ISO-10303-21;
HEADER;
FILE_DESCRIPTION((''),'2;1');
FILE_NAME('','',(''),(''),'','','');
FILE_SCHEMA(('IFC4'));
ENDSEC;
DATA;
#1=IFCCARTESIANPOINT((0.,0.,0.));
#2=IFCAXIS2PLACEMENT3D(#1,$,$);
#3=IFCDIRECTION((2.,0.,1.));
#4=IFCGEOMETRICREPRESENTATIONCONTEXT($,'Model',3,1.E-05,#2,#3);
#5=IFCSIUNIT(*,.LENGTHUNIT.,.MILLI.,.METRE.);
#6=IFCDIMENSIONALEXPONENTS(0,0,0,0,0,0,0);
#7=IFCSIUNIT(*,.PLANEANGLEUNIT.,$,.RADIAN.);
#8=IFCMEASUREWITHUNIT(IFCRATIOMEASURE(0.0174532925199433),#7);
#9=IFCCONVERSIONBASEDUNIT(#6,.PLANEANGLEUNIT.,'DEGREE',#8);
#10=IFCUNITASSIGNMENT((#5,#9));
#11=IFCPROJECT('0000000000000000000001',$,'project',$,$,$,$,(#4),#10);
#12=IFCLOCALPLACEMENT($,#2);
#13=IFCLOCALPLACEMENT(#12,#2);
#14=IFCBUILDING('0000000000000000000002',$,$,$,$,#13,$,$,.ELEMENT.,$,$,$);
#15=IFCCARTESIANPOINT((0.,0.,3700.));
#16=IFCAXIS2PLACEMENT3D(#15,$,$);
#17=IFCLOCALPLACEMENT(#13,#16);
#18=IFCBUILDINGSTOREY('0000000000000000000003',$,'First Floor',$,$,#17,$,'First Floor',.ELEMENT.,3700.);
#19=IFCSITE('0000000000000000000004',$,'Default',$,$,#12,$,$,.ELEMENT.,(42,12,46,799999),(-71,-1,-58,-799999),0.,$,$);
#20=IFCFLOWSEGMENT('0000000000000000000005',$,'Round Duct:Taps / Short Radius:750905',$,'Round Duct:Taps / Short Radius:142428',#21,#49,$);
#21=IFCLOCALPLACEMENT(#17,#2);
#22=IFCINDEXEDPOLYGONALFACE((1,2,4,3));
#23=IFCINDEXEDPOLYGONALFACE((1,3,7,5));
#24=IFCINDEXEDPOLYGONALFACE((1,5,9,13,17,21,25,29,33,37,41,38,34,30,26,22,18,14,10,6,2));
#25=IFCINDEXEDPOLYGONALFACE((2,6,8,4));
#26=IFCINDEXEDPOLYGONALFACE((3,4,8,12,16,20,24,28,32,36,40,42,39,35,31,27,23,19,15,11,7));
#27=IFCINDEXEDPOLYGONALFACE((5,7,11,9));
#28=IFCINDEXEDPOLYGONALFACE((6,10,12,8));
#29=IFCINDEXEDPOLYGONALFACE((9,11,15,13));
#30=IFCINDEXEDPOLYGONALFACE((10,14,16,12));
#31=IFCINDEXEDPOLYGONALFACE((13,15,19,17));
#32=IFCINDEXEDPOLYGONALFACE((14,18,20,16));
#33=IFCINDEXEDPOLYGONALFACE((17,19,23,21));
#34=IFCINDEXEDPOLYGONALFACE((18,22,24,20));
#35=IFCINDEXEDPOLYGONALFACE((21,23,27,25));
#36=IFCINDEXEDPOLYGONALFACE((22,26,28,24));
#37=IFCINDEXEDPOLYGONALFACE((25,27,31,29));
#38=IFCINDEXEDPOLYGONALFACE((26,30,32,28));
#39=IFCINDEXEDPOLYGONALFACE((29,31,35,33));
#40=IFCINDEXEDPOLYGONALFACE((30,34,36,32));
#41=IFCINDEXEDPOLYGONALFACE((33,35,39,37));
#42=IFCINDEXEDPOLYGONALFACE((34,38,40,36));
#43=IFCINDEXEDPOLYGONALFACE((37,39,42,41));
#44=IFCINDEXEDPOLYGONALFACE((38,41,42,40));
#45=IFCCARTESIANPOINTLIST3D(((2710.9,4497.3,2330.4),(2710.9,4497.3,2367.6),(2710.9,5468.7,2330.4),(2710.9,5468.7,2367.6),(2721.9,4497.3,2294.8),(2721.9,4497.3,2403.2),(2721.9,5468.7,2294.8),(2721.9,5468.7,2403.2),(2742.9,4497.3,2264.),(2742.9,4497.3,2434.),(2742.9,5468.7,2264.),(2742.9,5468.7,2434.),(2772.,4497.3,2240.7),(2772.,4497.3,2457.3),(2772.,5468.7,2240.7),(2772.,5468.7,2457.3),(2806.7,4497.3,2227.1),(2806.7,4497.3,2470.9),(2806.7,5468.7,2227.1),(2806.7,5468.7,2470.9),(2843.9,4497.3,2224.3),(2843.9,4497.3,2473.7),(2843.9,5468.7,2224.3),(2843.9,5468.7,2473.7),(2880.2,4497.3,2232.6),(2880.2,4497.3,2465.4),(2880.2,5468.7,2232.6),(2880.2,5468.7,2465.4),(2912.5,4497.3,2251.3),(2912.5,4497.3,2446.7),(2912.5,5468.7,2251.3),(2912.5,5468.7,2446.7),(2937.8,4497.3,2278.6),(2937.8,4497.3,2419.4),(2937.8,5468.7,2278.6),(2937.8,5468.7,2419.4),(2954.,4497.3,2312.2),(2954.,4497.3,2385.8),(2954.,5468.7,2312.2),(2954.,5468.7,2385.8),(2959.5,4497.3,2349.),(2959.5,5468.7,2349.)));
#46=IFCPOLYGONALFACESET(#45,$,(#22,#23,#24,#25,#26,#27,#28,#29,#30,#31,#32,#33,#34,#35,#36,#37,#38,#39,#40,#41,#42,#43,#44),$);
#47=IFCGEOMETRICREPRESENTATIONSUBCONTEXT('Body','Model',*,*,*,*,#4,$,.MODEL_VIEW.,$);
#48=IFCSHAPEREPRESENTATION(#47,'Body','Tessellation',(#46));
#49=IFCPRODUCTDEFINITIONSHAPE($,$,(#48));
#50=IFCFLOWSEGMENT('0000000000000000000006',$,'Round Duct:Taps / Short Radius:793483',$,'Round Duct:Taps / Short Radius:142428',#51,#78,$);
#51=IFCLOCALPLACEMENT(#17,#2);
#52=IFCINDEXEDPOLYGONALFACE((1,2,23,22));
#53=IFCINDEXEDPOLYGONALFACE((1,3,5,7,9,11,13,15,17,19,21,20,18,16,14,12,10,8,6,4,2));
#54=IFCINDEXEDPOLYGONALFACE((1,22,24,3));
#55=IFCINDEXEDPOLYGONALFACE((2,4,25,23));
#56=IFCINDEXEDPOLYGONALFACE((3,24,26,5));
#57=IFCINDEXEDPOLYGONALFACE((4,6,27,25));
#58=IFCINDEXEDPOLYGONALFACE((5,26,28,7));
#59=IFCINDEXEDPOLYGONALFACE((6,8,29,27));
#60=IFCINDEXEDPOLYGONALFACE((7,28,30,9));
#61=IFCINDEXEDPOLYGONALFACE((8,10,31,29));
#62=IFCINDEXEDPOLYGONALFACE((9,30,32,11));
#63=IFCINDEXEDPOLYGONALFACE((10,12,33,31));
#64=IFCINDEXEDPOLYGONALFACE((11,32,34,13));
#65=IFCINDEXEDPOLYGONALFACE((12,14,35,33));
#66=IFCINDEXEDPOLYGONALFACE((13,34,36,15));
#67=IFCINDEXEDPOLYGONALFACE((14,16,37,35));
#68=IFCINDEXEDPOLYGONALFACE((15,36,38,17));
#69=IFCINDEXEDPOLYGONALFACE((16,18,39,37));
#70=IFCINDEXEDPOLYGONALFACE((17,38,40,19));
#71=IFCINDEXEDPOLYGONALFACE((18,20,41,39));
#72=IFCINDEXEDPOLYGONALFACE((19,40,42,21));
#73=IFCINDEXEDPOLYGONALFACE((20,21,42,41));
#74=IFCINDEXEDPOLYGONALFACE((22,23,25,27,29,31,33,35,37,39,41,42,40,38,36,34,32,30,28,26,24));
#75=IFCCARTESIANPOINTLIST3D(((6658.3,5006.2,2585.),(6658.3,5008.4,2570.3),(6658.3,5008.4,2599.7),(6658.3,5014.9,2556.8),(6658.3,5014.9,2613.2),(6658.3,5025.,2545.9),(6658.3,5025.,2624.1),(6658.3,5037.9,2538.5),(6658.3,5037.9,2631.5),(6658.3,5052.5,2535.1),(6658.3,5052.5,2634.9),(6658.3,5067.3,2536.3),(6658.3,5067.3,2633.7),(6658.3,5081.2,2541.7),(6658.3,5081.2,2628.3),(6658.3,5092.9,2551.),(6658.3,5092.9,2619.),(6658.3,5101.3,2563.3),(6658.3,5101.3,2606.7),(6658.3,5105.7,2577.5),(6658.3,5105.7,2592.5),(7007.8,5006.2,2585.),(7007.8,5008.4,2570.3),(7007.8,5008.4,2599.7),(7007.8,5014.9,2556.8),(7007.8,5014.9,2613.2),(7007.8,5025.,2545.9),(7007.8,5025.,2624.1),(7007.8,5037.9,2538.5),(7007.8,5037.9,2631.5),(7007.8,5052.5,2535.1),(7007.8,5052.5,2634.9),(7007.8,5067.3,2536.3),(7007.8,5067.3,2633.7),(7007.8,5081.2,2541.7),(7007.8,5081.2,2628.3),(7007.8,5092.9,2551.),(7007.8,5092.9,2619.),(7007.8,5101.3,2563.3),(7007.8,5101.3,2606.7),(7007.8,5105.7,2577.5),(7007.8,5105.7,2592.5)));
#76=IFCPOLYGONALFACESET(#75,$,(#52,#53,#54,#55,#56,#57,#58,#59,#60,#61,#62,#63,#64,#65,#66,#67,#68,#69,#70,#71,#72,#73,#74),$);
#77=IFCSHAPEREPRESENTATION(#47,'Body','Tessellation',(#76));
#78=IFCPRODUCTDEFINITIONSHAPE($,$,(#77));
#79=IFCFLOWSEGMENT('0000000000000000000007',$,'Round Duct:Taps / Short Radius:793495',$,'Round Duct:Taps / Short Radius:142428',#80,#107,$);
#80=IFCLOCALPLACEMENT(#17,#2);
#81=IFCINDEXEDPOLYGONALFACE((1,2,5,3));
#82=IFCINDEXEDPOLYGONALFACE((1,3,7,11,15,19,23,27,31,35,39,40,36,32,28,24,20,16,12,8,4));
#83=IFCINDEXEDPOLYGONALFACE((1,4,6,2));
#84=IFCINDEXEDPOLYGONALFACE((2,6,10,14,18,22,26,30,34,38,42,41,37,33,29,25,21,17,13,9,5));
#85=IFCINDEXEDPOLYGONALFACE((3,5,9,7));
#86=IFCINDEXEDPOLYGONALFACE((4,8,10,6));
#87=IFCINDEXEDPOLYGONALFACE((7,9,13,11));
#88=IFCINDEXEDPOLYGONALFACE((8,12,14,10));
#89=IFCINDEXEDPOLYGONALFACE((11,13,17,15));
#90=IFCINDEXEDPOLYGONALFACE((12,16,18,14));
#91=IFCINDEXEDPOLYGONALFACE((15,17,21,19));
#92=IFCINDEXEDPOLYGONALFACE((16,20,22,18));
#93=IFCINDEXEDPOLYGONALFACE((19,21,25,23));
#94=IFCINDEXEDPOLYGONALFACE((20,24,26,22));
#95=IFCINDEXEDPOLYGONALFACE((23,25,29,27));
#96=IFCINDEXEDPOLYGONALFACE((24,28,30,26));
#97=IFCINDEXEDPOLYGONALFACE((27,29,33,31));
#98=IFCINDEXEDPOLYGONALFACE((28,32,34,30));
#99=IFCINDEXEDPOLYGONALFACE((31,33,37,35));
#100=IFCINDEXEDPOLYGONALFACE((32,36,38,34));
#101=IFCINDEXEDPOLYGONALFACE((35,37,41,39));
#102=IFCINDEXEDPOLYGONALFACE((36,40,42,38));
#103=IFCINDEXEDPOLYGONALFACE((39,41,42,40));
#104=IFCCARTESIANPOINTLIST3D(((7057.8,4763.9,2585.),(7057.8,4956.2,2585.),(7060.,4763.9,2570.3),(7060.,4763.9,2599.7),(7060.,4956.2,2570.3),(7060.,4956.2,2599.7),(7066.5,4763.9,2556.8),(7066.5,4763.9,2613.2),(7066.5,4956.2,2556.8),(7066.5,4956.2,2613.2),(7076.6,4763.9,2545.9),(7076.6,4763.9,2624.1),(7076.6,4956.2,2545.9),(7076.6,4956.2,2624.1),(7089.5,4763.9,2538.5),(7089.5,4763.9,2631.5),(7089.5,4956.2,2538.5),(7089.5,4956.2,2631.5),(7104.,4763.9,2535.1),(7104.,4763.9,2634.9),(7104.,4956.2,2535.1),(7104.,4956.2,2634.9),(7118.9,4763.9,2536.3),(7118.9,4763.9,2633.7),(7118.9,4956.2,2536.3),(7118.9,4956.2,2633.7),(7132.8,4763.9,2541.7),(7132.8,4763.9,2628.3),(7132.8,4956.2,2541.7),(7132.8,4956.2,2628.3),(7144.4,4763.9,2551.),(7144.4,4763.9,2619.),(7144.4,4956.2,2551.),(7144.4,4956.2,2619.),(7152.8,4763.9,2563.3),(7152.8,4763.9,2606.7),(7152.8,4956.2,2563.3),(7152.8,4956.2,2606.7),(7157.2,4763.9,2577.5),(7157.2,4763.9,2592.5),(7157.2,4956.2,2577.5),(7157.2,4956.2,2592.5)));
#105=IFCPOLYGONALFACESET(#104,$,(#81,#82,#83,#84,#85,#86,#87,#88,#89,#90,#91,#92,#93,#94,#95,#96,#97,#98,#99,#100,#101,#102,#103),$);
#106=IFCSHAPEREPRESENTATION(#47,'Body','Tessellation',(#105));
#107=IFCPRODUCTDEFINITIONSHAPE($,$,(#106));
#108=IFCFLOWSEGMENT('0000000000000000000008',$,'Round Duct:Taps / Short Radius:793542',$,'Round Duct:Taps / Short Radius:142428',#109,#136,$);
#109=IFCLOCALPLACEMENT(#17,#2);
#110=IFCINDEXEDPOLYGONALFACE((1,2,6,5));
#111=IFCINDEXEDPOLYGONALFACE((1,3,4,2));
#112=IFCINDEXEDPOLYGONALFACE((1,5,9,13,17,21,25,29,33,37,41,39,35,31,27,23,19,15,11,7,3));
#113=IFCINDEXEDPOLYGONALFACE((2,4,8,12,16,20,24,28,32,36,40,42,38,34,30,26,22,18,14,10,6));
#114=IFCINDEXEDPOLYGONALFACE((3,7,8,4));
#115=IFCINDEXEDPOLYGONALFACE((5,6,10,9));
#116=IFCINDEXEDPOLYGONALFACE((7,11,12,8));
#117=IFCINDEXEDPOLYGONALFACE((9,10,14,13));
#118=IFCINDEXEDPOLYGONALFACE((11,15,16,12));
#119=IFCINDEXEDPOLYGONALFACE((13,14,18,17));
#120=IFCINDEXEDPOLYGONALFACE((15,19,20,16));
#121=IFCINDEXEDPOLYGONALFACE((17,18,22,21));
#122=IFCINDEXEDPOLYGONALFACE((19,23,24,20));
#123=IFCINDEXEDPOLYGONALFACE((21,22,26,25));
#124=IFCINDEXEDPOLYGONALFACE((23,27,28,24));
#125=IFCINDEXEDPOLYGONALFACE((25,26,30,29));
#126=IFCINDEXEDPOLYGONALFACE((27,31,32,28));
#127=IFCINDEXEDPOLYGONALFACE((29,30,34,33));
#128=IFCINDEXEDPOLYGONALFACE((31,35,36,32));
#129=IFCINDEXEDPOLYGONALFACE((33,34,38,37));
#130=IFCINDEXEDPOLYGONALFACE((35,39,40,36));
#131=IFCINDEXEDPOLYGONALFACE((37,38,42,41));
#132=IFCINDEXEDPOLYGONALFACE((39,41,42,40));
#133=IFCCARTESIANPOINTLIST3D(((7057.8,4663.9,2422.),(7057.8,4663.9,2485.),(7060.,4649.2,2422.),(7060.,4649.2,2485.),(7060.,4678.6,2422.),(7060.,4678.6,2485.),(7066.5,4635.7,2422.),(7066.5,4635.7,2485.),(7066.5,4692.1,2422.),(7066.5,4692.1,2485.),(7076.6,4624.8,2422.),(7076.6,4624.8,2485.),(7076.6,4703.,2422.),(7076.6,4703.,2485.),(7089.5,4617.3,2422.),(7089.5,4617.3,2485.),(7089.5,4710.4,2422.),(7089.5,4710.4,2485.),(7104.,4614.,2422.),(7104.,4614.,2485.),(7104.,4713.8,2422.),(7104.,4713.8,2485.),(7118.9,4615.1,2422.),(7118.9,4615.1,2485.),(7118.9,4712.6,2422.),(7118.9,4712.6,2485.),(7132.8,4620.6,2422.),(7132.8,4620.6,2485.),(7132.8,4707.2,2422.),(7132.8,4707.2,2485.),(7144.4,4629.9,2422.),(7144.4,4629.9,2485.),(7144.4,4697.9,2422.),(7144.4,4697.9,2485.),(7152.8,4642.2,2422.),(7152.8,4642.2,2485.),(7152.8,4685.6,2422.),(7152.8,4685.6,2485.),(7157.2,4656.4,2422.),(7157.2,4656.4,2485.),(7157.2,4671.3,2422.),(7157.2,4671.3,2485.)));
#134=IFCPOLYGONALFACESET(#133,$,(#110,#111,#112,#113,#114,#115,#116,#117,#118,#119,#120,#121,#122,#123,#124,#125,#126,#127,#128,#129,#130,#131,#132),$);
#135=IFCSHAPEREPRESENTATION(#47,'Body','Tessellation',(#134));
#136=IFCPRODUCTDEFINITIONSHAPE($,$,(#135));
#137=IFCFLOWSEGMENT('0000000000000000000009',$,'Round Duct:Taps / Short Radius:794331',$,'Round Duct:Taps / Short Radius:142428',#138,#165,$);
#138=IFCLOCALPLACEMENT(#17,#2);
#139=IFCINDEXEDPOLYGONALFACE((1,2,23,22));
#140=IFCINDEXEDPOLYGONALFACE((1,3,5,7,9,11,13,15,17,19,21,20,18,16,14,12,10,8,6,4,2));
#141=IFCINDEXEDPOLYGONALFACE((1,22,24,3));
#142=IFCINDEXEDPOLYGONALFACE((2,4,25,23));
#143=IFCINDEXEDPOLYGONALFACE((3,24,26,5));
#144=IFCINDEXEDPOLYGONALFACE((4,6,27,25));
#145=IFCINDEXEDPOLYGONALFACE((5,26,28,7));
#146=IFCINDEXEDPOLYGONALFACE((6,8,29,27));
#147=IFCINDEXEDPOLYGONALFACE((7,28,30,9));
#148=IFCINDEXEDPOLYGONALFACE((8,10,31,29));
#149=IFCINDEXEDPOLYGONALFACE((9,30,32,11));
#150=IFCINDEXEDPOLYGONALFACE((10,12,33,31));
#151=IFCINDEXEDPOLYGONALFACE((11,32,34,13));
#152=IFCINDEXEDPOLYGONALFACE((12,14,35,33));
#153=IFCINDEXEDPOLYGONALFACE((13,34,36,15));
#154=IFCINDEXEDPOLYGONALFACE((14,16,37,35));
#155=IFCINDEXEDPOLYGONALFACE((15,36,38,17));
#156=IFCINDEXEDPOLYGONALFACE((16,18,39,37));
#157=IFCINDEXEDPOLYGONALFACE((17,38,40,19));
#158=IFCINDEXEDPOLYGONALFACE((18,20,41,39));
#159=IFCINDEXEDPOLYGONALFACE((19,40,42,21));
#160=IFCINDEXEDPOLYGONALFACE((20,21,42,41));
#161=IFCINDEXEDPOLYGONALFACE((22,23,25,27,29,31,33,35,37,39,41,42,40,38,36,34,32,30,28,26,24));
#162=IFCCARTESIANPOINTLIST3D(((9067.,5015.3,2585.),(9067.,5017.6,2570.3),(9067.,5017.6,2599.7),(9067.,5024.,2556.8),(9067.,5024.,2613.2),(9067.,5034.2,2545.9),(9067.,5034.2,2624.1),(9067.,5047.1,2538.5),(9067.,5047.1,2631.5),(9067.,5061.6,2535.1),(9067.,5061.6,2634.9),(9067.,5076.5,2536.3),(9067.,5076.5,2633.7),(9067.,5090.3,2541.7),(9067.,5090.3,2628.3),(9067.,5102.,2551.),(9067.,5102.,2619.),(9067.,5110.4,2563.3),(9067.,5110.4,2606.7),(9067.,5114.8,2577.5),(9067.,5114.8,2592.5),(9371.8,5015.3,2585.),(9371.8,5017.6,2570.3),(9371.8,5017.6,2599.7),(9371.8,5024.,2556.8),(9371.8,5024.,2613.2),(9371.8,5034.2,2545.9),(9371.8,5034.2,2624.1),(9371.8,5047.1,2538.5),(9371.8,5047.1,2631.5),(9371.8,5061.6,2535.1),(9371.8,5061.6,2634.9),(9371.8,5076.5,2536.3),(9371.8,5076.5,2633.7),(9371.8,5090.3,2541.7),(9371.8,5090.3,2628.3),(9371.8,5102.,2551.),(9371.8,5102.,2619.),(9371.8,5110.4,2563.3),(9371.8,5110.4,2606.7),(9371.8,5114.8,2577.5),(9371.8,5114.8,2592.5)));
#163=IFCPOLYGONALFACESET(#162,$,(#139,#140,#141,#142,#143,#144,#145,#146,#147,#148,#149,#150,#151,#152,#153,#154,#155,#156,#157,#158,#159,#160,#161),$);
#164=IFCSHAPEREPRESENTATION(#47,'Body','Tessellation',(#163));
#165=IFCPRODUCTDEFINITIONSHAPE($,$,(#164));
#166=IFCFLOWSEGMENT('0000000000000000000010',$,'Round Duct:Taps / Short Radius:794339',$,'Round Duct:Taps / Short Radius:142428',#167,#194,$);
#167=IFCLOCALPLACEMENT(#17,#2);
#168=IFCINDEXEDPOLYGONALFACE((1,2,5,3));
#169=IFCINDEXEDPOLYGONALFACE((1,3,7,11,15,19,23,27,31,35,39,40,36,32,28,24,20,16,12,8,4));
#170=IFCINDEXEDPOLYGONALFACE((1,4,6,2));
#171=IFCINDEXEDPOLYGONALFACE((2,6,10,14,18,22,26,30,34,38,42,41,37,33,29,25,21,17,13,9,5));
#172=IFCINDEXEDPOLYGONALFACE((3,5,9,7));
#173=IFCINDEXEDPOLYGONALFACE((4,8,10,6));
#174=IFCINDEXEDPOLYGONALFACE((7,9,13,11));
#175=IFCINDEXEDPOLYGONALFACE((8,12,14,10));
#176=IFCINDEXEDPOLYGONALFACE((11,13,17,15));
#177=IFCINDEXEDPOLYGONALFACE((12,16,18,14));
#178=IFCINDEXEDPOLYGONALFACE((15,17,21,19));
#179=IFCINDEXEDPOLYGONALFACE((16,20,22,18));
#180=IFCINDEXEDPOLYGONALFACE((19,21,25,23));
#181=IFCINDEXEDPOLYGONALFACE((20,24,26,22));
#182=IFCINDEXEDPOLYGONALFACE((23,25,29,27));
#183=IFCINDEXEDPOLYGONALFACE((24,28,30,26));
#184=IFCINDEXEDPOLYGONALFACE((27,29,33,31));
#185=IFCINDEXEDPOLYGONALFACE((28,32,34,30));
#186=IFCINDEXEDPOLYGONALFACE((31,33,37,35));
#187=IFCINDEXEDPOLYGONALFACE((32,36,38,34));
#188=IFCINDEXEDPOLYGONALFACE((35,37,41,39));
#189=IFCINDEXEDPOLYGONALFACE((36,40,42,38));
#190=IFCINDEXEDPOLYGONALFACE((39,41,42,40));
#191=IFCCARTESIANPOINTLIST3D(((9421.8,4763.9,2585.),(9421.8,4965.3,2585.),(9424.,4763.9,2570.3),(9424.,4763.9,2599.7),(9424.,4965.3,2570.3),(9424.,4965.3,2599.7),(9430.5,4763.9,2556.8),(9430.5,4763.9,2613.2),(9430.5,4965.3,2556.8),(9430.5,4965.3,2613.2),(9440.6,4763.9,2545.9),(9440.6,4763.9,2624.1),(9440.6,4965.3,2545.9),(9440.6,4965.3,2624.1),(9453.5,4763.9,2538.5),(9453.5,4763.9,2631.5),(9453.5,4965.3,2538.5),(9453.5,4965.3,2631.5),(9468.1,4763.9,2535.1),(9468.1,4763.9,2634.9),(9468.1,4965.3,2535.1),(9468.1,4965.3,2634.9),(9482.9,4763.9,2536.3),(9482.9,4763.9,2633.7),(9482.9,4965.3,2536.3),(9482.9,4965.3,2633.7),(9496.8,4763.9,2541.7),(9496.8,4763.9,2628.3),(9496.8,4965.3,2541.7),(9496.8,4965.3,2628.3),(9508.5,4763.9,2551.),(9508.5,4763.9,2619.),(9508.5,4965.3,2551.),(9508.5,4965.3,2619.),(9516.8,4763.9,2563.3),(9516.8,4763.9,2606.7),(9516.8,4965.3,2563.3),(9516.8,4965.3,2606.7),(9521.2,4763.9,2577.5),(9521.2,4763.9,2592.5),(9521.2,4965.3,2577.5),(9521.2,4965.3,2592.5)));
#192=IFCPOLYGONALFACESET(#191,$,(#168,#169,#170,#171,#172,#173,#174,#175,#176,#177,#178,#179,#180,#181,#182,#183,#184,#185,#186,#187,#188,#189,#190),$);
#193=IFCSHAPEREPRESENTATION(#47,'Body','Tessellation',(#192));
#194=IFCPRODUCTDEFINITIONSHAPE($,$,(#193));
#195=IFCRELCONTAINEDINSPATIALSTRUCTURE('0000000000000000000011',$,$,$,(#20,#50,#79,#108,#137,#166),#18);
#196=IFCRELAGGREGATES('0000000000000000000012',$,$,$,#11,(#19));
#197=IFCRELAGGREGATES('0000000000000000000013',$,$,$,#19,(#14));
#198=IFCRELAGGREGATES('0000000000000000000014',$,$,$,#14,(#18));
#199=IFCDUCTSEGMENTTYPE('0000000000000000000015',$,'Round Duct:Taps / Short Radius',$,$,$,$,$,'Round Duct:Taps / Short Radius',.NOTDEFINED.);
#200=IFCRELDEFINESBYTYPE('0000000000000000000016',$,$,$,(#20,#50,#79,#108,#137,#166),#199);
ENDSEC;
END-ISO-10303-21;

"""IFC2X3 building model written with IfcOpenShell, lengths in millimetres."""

from ifc_helpers import new_model, entity, si_unit, converted_unit, direction, frame, frame_2d, origin, origin_2d_with_axis, place, context, subcontext, project, spatial, circle, extrude, type_object, element, save


model = new_model("IFC2X3")

# Units and contexts
model_context = context("Model", 3, precision=1e-05, world=origin(), true_north=direction((2.0, 0.0, 1.0)))
body_context = subcontext(model_context, "Body", "Model", "MODEL_VIEW")
ifc_project = project(units=[si_unit("LENGTHUNIT", "METRE", prefix="MILLI"), converted_unit("PLANEANGLEUNIT", "DEGREE", entity("IfcRatioMeasure", 0.0174532925199433), si_unit("PLANEANGLEUNIT", "RADIAN"), dimensions=[0, 0, 0, 0, 0, 0, 0])], contexts=[model_context])

# Site, building, storey
site_placement = place(None, origin())
site = spatial("IfcSite", under=ifc_project, at=site_placement, Name="Default", CompositionType="ELEMENT", RefLatitude=(42, 12, 46, 799999), RefLongitude=(-71, -1, -58, -799999), RefElevation=0.0)
building_placement = place(site_placement, origin())
building = spatial("IfcBuilding", under=site, at=building_placement, CompositionType="ELEMENT")
storey_placement = place(building_placement, frame((0.0, 0.0, 3700.0)))
storey = spatial("IfcBuildingStorey", under=building, at=storey_placement, Name="First Floor", LongName="First Floor", CompositionType="ELEMENT", Elevation=3700.0)

# Flow segments
duct_segment_type_1 = type_object("IfcDuctSegmentType", Name="Round Duct:Taps / Short Radius", ElementType="Round Duct:Taps / Short Radius", PredefinedType="NOTDEFINED")
flow_segment_1_placement = place(storey_placement, origin())
element("IfcFlowSegment", 1, at=flow_segment_1_placement, inside=storey, type_object=duct_segment_type_1, Name="Round Duct:Taps / Short Radius:750905", ObjectType="Round Duct:Taps / Short Radius:142428", context=body_context, shape_type="SweptSolid", body=[
    extrude(circle(Radius=125.0, at=frame_2d((0.0, 0.0), x_axis=(1.0, 0.0))), frame((2834.5, 4497.3, 2349.0), z_axis=(0.0, 1.0, 0.0), x_axis=(1.0, 0.0, 0.0)), (0.0, 0.0, 1.0), 971.4),
])
flow_segment_2_placement = place(storey_placement, origin())
element("IfcFlowSegment", 2, at=flow_segment_2_placement, inside=storey, type_object=duct_segment_type_1, Name="Round Duct:Taps / Short Radius:793483", ObjectType="Round Duct:Taps / Short Radius:142428", context=body_context, shape_type="SweptSolid", body=[
    extrude(circle(Radius=50.0, at=origin_2d_with_axis()), frame((6658.3, 5056.2, 2585.0), z_axis=(1.0, 0.0, 0.0), x_axis=(0.0, -1.0, 0.0)), (0.0, 0.0, 1.0), 349.4),
])
flow_segment_3_placement = place(storey_placement, origin())
element("IfcFlowSegment", 3, at=flow_segment_3_placement, inside=storey, type_object=duct_segment_type_1, Name="Round Duct:Taps / Short Radius:793495", ObjectType="Round Duct:Taps / Short Radius:142428", context=body_context, shape_type="SweptSolid", body=[
    extrude(circle(Radius=50.0, at=frame_2d((0.0, 0.0), x_axis=(1.0, 0.0))), frame((7107.8, 4763.9, 2585.0), z_axis=(0.0, 1.0, 0.0), x_axis=(-1.0, 0.0, 0.0)), (0.0, 0.0, 1.0), 192.3),
])
flow_segment_4_placement = place(storey_placement, origin())
element("IfcFlowSegment", 4, at=flow_segment_4_placement, inside=storey, type_object=duct_segment_type_1, Name="Round Duct:Taps / Short Radius:793542", ObjectType="Round Duct:Taps / Short Radius:142428", context=body_context, shape_type="SweptSolid", body=[
    extrude(circle(Radius=50.0, at=frame_2d((0.0, 0.0), x_axis=(1.0, 0.0))), frame((7107.8, 4663.9, 2422.0), z_axis=(0.0, 0.0, 1.0), x_axis=(-1.0, 0.0, 0.0)), (0.0, 0.0, 1.0), 63.0),
])
flow_segment_5_placement = place(storey_placement, origin())
element("IfcFlowSegment", 5, at=flow_segment_5_placement, inside=storey, type_object=duct_segment_type_1, Name="Round Duct:Taps / Short Radius:794331", ObjectType="Round Duct:Taps / Short Radius:142428", context=body_context, shape_type="SweptSolid", body=[
    extrude(circle(Radius=50.0, at=origin_2d_with_axis()), frame((9067.0, 5065.3, 2585.0), z_axis=(1.0, 0.0, 0.0), x_axis=(0.0, -1.0, 0.0)), (0.0, 0.0, 1.0), 304.8),
])
flow_segment_6_placement = place(storey_placement, origin())
element("IfcFlowSegment", 6, at=flow_segment_6_placement, inside=storey, type_object=duct_segment_type_1, Name="Round Duct:Taps / Short Radius:794339", ObjectType="Round Duct:Taps / Short Radius:142428", context=body_context, shape_type="SweptSolid", body=[
    extrude(circle(Radius=50.0, at=frame_2d((0.0, 0.0), x_axis=(1.0, 0.0))), frame((9471.8, 4763.9, 2585.0), z_axis=(0.0, 1.0, 0.0), x_axis=(-1.0, 0.0, 0.0)), (0.0, 0.0, 1.0), 201.5),
])

save(model, "model.ifc")
